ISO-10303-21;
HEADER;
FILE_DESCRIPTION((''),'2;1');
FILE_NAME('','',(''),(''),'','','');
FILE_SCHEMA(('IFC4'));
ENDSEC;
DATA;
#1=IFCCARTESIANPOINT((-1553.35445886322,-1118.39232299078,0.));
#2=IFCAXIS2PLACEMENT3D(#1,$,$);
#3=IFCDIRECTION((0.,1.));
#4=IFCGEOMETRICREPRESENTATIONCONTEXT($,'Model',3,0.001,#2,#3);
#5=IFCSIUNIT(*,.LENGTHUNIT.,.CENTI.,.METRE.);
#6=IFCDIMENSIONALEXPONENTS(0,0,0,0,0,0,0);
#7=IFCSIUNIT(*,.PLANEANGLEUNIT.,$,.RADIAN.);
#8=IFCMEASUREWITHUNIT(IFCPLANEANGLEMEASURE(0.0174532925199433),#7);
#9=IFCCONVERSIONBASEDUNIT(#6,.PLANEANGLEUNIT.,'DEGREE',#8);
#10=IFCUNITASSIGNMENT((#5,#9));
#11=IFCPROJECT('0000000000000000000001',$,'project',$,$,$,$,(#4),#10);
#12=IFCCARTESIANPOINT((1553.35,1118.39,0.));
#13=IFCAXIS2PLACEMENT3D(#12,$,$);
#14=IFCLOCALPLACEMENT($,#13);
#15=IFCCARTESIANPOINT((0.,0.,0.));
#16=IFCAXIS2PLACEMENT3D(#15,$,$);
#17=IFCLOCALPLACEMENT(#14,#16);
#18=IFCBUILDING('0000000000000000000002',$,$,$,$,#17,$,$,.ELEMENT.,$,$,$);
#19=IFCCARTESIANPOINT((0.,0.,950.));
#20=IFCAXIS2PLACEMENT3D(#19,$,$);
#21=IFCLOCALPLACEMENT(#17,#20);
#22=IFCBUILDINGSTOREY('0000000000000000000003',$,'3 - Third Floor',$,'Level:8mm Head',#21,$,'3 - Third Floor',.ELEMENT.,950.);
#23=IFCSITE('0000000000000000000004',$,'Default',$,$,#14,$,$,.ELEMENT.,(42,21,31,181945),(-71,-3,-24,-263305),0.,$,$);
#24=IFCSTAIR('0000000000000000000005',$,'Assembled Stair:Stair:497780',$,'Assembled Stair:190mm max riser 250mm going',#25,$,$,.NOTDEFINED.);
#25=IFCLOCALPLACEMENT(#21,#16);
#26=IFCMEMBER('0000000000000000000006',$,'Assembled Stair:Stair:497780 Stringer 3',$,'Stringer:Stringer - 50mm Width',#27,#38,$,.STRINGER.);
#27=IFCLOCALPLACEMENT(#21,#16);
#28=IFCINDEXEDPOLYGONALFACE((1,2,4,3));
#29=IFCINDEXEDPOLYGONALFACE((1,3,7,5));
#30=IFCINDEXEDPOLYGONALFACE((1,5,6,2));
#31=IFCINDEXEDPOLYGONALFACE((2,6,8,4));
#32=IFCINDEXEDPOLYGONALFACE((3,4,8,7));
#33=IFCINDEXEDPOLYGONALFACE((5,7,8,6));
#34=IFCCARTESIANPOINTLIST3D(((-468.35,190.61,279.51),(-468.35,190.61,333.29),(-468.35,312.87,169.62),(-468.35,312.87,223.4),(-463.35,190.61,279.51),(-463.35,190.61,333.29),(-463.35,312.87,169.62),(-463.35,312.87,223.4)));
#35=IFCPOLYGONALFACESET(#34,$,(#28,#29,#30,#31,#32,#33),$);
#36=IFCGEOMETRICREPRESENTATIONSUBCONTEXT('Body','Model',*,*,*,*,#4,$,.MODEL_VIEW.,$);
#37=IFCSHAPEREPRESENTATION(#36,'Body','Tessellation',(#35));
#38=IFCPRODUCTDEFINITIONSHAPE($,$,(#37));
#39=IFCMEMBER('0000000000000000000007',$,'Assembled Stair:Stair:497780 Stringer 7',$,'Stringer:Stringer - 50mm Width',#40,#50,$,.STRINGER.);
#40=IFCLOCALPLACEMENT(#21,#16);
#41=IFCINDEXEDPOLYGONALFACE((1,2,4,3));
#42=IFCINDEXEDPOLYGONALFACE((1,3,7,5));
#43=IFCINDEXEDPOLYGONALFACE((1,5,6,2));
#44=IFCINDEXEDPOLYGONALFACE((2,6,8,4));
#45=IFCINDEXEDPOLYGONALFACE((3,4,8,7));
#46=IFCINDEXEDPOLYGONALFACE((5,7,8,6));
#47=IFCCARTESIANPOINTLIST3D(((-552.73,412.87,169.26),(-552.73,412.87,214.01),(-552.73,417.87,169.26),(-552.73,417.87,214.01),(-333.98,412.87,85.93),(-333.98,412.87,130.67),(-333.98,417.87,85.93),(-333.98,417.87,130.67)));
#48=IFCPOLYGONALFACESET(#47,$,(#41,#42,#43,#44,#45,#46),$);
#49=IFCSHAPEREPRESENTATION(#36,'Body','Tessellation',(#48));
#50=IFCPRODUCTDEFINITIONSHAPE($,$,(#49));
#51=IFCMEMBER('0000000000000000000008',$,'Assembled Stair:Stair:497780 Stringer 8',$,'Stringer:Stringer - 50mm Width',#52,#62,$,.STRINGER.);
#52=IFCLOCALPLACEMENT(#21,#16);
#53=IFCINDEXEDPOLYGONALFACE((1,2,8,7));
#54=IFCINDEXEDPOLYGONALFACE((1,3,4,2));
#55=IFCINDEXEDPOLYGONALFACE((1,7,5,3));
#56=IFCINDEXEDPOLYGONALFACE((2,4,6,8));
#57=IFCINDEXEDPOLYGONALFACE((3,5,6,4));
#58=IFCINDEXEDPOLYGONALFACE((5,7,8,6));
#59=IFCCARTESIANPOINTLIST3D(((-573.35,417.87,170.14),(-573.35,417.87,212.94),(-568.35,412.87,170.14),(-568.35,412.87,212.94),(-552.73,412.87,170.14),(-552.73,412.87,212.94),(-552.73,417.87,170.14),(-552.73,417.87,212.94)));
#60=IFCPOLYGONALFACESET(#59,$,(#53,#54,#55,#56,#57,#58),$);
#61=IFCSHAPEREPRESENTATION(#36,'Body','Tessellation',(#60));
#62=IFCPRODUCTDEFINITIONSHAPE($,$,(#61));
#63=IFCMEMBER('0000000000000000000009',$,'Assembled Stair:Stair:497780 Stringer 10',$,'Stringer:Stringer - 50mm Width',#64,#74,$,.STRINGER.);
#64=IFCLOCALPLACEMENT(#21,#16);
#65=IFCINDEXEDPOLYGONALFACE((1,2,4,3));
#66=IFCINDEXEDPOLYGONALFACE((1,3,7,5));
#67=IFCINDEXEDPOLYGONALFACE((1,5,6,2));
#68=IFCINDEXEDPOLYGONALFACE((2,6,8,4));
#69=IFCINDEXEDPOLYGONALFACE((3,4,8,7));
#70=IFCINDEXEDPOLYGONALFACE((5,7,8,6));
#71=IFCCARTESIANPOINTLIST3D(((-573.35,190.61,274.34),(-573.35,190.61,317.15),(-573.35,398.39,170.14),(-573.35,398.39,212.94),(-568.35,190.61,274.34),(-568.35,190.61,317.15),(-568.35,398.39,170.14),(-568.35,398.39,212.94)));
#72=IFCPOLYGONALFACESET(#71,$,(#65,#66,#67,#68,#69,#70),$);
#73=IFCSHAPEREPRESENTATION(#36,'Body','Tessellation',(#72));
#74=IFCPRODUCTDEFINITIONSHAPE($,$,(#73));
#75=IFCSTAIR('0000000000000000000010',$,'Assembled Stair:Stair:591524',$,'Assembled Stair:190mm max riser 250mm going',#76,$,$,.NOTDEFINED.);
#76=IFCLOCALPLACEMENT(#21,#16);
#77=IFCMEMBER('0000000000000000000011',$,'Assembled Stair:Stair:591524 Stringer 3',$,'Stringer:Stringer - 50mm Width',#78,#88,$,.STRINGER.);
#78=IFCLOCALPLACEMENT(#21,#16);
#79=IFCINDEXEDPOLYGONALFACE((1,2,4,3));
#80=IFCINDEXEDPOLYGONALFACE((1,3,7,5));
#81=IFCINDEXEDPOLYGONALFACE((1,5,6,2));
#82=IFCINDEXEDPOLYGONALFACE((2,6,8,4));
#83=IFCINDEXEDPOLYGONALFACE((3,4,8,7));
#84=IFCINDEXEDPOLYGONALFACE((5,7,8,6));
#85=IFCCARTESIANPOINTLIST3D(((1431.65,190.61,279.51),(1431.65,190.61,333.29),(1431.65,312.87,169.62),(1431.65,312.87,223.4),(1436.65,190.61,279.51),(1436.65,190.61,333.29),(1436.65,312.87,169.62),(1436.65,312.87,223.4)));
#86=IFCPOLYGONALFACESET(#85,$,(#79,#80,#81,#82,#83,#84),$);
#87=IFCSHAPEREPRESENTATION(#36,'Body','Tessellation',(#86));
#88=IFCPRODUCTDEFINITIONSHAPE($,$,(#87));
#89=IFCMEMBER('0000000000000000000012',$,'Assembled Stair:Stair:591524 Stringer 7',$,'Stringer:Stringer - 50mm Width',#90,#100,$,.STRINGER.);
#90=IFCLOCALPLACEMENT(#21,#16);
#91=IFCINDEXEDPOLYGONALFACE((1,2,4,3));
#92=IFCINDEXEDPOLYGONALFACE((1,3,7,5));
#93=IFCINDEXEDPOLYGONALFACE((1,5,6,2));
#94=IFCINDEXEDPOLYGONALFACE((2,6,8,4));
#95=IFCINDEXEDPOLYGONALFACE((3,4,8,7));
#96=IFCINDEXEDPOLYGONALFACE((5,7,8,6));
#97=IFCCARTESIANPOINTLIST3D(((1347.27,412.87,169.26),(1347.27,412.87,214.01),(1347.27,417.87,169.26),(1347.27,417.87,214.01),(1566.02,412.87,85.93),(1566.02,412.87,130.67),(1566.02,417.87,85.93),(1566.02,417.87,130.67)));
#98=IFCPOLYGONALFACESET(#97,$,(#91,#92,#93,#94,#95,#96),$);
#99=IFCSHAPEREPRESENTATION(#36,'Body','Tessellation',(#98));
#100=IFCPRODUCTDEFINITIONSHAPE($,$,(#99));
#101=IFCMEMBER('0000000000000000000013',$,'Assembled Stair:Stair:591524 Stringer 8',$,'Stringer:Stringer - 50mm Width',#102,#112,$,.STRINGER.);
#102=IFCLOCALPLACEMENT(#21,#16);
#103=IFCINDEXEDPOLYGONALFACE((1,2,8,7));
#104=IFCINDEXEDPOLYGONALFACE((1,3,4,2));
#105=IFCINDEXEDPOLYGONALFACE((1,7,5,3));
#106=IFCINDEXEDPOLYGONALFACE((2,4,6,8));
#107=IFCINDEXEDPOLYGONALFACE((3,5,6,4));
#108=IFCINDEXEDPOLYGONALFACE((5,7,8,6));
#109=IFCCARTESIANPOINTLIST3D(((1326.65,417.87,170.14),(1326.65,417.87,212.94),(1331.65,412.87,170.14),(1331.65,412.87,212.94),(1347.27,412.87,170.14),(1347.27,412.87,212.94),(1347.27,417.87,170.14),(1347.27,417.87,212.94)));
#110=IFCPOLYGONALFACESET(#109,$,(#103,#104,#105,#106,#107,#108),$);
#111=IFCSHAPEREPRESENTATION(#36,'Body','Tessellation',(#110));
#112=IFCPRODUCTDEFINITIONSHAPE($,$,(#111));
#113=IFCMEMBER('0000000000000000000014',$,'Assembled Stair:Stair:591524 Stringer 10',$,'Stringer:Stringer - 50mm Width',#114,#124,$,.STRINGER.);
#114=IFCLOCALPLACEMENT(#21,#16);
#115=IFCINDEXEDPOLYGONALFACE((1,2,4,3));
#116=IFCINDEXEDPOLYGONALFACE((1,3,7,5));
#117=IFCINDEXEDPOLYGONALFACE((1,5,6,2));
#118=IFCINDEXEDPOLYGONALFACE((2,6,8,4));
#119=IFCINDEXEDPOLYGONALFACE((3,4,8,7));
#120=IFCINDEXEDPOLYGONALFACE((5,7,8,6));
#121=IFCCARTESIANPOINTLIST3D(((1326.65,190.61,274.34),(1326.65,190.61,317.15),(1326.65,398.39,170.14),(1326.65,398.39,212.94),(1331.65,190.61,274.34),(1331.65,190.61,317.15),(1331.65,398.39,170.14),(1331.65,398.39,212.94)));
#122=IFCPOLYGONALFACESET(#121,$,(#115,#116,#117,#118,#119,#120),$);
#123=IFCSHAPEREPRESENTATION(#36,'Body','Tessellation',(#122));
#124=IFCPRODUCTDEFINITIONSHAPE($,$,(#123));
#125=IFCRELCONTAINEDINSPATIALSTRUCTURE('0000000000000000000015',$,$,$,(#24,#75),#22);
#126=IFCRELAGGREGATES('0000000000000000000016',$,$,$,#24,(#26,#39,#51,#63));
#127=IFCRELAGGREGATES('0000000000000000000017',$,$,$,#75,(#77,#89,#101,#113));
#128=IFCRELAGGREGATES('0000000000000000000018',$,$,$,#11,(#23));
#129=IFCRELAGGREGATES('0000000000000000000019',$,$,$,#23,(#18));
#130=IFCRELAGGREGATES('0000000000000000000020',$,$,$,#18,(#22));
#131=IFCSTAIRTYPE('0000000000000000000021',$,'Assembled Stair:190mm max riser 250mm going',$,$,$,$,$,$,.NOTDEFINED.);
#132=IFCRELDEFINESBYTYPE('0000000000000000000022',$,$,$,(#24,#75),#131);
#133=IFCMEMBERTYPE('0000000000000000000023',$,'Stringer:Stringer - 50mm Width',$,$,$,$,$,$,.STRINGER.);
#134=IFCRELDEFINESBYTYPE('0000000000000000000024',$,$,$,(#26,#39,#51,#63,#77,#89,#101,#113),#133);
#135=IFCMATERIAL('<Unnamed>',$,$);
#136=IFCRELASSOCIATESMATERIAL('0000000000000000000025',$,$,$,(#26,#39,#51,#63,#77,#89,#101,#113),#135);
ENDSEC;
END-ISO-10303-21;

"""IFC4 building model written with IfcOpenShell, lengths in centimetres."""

from ifc_helpers import new_model, entity, si_unit, converted_unit, direction, frame, origin, place, context, subcontext, project, spatial, indexed_curve, outline, extrude, material, type_object, element, aggregate, save


model = new_model("IFC4")

# Units and contexts
model_context = context("Model", 3, precision=0.001, world=frame((-1553.35445886322, -1118.39232299078, 0.0)), true_north=direction((0.0, 1.0)))
body_context = subcontext(model_context, "Body", "Model", "MODEL_VIEW")
ifc_project = project(units=[si_unit("LENGTHUNIT", "METRE", prefix="CENTI"), converted_unit("PLANEANGLEUNIT", "DEGREE", entity("IfcPlaneAngleMeasure", 0.0174532925199433), si_unit("PLANEANGLEUNIT", "RADIAN"), dimensions=[0, 0, 0, 0, 0, 0, 0])], contexts=[model_context])

# Site, building, storey
site_placement = place(None, frame((1553.35, 1118.39, 0.0)))
site = spatial("IfcSite", under=ifc_project, at=site_placement, Name="Default", CompositionType="ELEMENT", RefLatitude=(42, 21, 31, 181945), RefLongitude=(-71, -3, -24, -263305), RefElevation=0.0)
building_placement = place(site_placement, origin())
building = spatial("IfcBuilding", under=site, at=building_placement, CompositionType="ELEMENT")
storey_placement = place(building_placement, frame((0.0, 0.0, 950.0)))
storey = spatial("IfcBuildingStorey", under=building, at=storey_placement, Name="3 - Third Floor", ObjectType="Level:8mm Head", LongName="3 - Third Floor", CompositionType="ELEMENT", Elevation=950.0)

# Stair, members
stair_type = type_object("IfcStairType", Name="Assembled Stair:190mm max riser 250mm going", PredefinedType="NOTDEFINED")
stair_1_placement = place(storey_placement, origin())
stair_1 = element("IfcStair", 1, at=stair_1_placement, inside=storey, type_object=stair_type, Name="Assembled Stair:Stair:497780", ObjectType="Assembled Stair:190mm max riser 250mm going", PredefinedType="NOTDEFINED")
ifc_material = material(Name="<Unnamed>")
member_type = type_object("IfcMemberType", Name="Stringer:Stringer - 50mm Width", PredefinedType="STRINGER")
member_1_placement = place(stair_1_placement, origin())
member_1 = element("IfcMember", 2, at=member_1_placement, type_object=member_type, material=ifc_material, Name="Assembled Stair:Stair:497780 Stringer 3", ObjectType="Stringer:Stringer - 50mm Width", PredefinedType="STRINGER", context=body_context, shape_type="SweptSolid", body=[
    extrude(outline(indexed_curve([(-64.22, -20.0), (100.17, -20.0), (64.22, 20.0), (-100.17, 20.0), (-64.22, -20.0)], self_intersect=False)), frame((-468.35, 251.74, 251.46), z_axis=(1.0, 0.0, 0.0), x_axis=(0.0, -0.74373, 0.668481)), (0.0, 0.0, 1.0), 5.0),
])
member_2_placement = place(stair_1_placement, origin())
member_2 = element("IfcMember", 3, at=member_2_placement, type_object=member_type, material=ifc_material, Name="Assembled Stair:Stair:497780 Stringer 7", ObjectType="Stringer:Stringer - 50mm Width", PredefinedType="STRINGER", context=body_context, shape_type="SweptSolid", body=[
    extrude(outline(indexed_curve([(-125.01, -20.91), (109.08, -20.91), (125.01, 20.91), (-109.08, 20.91), (-125.01, -20.91)], self_intersect=False)), frame((-443.35, 412.87, 149.97), z_axis=(0.0, 1.0, 0.0), x_axis=(-0.934489, 0.0, 0.355992)), (0.0, 0.0, 1.0), 5.0),
])
member_3_placement = place(stair_1_placement, origin())
member_3 = element("IfcMember", 4, at=member_3_placement, type_object=member_type, material=ifc_material, Name="Assembled Stair:Stair:497780 Stringer 8", ObjectType="Stringer:Stringer - 50mm Width", PredefinedType="STRINGER", context=body_context, shape_type="SweptSolid", body=[
    extrude(outline(indexed_curve([(-9.06, -2.5), (11.56, -2.5), (6.56, 2.5), (-9.06, 2.5), (-9.06, -2.5)], self_intersect=False)), frame((-561.79, 415.37, 170.14), z_axis=(0.0, 0.0, 1.0), x_axis=(-1.0, 0.0, 0.0)), (0.0, 0.0, 1.0), 42.8),
])
member_4_placement = place(stair_1_placement, origin())
member_4 = element("IfcMember", 5, at=member_4_placement, type_object=member_type, material=ifc_material, Name="Assembled Stair:Stair:497780 Stringer 10", ObjectType="Stringer:Stringer - 50mm Width", PredefinedType="STRINGER", context=body_context, shape_type="SweptSolid", body=[
    extrude(outline(indexed_curve([(-106.63, -19.13), (125.82, -19.13), (106.63, 19.13), (-125.82, 19.13), (-106.63, -19.13)], self_intersect=False)), frame((-573.35, 294.5, 243.64), z_axis=(1.0, 0.0, 0.0), x_axis=(0.0, -0.893886, 0.448294)), (0.0, 0.0, 1.0), 5.0),
])
aggregate(stair_1, [member_1, member_2, member_3, member_4])

# Stair, members
stair_2_placement = place(storey_placement, origin())
stair_2 = element("IfcStair", 6, at=stair_2_placement, inside=storey, type_object=stair_type, Name="Assembled Stair:Stair:591524", ObjectType="Assembled Stair:190mm max riser 250mm going", PredefinedType="NOTDEFINED")
member_5_placement = place(stair_2_placement, origin())
member_5 = element("IfcMember", 7, at=member_5_placement, type_object=member_type, material=ifc_material, Name="Assembled Stair:Stair:591524 Stringer 3", ObjectType="Stringer:Stringer - 50mm Width", PredefinedType="STRINGER", context=body_context, shape_type="SweptSolid", body=[
    extrude(outline(indexed_curve([(-64.22, -20.0), (100.17, -20.0), (64.22, 20.0), (-100.17, 20.0), (-64.22, -20.0)], self_intersect=False)), frame((1431.65, 251.74, 251.46), z_axis=(1.0, 0.0, 0.0), x_axis=(0.0, -0.74373, 0.668481)), (0.0, 0.0, 1.0), 5.0),
])
member_6_placement = place(stair_2_placement, origin())
member_6 = element("IfcMember", 8, at=member_6_placement, type_object=member_type, material=ifc_material, Name="Assembled Stair:Stair:591524 Stringer 7", ObjectType="Stringer:Stringer - 50mm Width", PredefinedType="STRINGER", context=body_context, shape_type="SweptSolid", body=[
    extrude(outline(indexed_curve([(-125.01, -20.91), (109.08, -20.91), (125.01, 20.91), (-109.08, 20.91), (-125.01, -20.91)], self_intersect=False)), frame((1456.65, 412.87, 149.97), z_axis=(0.0, 1.0, 0.0), x_axis=(-0.934489, 0.0, 0.355992)), (0.0, 0.0, 1.0), 5.0),
])
member_7_placement = place(stair_2_placement, origin())
member_7 = element("IfcMember", 9, at=member_7_placement, type_object=member_type, material=ifc_material, Name="Assembled Stair:Stair:591524 Stringer 8", ObjectType="Stringer:Stringer - 50mm Width", PredefinedType="STRINGER", context=body_context, shape_type="SweptSolid", body=[
    extrude(outline(indexed_curve([(-9.06, -2.5), (11.56, -2.5), (6.56, 2.5), (-9.06, 2.5), (-9.06, -2.5)], self_intersect=False)), frame((1338.21, 415.37, 170.14), z_axis=(0.0, 0.0, 1.0), x_axis=(-1.0, 0.0, 0.0)), (0.0, 0.0, 1.0), 42.8),
])
member_8_placement = place(stair_2_placement, origin())
member_8 = element("IfcMember", 10, at=member_8_placement, type_object=member_type, material=ifc_material, Name="Assembled Stair:Stair:591524 Stringer 10", ObjectType="Stringer:Stringer - 50mm Width", PredefinedType="STRINGER", context=body_context, shape_type="SweptSolid", body=[
    extrude(outline(indexed_curve([(-106.63, -19.13), (125.82, -19.13), (106.63, 19.13), (-125.82, 19.13), (-106.63, -19.13)], self_intersect=False)), frame((1326.65, 294.5, 243.64), z_axis=(1.0, 0.0, 0.0), x_axis=(0.0, -0.893886, 0.448294)), (0.0, 0.0, 1.0), 5.0),
])
aggregate(stair_2, [member_5, member_6, member_7, member_8])

save(model, "model.ifc")
